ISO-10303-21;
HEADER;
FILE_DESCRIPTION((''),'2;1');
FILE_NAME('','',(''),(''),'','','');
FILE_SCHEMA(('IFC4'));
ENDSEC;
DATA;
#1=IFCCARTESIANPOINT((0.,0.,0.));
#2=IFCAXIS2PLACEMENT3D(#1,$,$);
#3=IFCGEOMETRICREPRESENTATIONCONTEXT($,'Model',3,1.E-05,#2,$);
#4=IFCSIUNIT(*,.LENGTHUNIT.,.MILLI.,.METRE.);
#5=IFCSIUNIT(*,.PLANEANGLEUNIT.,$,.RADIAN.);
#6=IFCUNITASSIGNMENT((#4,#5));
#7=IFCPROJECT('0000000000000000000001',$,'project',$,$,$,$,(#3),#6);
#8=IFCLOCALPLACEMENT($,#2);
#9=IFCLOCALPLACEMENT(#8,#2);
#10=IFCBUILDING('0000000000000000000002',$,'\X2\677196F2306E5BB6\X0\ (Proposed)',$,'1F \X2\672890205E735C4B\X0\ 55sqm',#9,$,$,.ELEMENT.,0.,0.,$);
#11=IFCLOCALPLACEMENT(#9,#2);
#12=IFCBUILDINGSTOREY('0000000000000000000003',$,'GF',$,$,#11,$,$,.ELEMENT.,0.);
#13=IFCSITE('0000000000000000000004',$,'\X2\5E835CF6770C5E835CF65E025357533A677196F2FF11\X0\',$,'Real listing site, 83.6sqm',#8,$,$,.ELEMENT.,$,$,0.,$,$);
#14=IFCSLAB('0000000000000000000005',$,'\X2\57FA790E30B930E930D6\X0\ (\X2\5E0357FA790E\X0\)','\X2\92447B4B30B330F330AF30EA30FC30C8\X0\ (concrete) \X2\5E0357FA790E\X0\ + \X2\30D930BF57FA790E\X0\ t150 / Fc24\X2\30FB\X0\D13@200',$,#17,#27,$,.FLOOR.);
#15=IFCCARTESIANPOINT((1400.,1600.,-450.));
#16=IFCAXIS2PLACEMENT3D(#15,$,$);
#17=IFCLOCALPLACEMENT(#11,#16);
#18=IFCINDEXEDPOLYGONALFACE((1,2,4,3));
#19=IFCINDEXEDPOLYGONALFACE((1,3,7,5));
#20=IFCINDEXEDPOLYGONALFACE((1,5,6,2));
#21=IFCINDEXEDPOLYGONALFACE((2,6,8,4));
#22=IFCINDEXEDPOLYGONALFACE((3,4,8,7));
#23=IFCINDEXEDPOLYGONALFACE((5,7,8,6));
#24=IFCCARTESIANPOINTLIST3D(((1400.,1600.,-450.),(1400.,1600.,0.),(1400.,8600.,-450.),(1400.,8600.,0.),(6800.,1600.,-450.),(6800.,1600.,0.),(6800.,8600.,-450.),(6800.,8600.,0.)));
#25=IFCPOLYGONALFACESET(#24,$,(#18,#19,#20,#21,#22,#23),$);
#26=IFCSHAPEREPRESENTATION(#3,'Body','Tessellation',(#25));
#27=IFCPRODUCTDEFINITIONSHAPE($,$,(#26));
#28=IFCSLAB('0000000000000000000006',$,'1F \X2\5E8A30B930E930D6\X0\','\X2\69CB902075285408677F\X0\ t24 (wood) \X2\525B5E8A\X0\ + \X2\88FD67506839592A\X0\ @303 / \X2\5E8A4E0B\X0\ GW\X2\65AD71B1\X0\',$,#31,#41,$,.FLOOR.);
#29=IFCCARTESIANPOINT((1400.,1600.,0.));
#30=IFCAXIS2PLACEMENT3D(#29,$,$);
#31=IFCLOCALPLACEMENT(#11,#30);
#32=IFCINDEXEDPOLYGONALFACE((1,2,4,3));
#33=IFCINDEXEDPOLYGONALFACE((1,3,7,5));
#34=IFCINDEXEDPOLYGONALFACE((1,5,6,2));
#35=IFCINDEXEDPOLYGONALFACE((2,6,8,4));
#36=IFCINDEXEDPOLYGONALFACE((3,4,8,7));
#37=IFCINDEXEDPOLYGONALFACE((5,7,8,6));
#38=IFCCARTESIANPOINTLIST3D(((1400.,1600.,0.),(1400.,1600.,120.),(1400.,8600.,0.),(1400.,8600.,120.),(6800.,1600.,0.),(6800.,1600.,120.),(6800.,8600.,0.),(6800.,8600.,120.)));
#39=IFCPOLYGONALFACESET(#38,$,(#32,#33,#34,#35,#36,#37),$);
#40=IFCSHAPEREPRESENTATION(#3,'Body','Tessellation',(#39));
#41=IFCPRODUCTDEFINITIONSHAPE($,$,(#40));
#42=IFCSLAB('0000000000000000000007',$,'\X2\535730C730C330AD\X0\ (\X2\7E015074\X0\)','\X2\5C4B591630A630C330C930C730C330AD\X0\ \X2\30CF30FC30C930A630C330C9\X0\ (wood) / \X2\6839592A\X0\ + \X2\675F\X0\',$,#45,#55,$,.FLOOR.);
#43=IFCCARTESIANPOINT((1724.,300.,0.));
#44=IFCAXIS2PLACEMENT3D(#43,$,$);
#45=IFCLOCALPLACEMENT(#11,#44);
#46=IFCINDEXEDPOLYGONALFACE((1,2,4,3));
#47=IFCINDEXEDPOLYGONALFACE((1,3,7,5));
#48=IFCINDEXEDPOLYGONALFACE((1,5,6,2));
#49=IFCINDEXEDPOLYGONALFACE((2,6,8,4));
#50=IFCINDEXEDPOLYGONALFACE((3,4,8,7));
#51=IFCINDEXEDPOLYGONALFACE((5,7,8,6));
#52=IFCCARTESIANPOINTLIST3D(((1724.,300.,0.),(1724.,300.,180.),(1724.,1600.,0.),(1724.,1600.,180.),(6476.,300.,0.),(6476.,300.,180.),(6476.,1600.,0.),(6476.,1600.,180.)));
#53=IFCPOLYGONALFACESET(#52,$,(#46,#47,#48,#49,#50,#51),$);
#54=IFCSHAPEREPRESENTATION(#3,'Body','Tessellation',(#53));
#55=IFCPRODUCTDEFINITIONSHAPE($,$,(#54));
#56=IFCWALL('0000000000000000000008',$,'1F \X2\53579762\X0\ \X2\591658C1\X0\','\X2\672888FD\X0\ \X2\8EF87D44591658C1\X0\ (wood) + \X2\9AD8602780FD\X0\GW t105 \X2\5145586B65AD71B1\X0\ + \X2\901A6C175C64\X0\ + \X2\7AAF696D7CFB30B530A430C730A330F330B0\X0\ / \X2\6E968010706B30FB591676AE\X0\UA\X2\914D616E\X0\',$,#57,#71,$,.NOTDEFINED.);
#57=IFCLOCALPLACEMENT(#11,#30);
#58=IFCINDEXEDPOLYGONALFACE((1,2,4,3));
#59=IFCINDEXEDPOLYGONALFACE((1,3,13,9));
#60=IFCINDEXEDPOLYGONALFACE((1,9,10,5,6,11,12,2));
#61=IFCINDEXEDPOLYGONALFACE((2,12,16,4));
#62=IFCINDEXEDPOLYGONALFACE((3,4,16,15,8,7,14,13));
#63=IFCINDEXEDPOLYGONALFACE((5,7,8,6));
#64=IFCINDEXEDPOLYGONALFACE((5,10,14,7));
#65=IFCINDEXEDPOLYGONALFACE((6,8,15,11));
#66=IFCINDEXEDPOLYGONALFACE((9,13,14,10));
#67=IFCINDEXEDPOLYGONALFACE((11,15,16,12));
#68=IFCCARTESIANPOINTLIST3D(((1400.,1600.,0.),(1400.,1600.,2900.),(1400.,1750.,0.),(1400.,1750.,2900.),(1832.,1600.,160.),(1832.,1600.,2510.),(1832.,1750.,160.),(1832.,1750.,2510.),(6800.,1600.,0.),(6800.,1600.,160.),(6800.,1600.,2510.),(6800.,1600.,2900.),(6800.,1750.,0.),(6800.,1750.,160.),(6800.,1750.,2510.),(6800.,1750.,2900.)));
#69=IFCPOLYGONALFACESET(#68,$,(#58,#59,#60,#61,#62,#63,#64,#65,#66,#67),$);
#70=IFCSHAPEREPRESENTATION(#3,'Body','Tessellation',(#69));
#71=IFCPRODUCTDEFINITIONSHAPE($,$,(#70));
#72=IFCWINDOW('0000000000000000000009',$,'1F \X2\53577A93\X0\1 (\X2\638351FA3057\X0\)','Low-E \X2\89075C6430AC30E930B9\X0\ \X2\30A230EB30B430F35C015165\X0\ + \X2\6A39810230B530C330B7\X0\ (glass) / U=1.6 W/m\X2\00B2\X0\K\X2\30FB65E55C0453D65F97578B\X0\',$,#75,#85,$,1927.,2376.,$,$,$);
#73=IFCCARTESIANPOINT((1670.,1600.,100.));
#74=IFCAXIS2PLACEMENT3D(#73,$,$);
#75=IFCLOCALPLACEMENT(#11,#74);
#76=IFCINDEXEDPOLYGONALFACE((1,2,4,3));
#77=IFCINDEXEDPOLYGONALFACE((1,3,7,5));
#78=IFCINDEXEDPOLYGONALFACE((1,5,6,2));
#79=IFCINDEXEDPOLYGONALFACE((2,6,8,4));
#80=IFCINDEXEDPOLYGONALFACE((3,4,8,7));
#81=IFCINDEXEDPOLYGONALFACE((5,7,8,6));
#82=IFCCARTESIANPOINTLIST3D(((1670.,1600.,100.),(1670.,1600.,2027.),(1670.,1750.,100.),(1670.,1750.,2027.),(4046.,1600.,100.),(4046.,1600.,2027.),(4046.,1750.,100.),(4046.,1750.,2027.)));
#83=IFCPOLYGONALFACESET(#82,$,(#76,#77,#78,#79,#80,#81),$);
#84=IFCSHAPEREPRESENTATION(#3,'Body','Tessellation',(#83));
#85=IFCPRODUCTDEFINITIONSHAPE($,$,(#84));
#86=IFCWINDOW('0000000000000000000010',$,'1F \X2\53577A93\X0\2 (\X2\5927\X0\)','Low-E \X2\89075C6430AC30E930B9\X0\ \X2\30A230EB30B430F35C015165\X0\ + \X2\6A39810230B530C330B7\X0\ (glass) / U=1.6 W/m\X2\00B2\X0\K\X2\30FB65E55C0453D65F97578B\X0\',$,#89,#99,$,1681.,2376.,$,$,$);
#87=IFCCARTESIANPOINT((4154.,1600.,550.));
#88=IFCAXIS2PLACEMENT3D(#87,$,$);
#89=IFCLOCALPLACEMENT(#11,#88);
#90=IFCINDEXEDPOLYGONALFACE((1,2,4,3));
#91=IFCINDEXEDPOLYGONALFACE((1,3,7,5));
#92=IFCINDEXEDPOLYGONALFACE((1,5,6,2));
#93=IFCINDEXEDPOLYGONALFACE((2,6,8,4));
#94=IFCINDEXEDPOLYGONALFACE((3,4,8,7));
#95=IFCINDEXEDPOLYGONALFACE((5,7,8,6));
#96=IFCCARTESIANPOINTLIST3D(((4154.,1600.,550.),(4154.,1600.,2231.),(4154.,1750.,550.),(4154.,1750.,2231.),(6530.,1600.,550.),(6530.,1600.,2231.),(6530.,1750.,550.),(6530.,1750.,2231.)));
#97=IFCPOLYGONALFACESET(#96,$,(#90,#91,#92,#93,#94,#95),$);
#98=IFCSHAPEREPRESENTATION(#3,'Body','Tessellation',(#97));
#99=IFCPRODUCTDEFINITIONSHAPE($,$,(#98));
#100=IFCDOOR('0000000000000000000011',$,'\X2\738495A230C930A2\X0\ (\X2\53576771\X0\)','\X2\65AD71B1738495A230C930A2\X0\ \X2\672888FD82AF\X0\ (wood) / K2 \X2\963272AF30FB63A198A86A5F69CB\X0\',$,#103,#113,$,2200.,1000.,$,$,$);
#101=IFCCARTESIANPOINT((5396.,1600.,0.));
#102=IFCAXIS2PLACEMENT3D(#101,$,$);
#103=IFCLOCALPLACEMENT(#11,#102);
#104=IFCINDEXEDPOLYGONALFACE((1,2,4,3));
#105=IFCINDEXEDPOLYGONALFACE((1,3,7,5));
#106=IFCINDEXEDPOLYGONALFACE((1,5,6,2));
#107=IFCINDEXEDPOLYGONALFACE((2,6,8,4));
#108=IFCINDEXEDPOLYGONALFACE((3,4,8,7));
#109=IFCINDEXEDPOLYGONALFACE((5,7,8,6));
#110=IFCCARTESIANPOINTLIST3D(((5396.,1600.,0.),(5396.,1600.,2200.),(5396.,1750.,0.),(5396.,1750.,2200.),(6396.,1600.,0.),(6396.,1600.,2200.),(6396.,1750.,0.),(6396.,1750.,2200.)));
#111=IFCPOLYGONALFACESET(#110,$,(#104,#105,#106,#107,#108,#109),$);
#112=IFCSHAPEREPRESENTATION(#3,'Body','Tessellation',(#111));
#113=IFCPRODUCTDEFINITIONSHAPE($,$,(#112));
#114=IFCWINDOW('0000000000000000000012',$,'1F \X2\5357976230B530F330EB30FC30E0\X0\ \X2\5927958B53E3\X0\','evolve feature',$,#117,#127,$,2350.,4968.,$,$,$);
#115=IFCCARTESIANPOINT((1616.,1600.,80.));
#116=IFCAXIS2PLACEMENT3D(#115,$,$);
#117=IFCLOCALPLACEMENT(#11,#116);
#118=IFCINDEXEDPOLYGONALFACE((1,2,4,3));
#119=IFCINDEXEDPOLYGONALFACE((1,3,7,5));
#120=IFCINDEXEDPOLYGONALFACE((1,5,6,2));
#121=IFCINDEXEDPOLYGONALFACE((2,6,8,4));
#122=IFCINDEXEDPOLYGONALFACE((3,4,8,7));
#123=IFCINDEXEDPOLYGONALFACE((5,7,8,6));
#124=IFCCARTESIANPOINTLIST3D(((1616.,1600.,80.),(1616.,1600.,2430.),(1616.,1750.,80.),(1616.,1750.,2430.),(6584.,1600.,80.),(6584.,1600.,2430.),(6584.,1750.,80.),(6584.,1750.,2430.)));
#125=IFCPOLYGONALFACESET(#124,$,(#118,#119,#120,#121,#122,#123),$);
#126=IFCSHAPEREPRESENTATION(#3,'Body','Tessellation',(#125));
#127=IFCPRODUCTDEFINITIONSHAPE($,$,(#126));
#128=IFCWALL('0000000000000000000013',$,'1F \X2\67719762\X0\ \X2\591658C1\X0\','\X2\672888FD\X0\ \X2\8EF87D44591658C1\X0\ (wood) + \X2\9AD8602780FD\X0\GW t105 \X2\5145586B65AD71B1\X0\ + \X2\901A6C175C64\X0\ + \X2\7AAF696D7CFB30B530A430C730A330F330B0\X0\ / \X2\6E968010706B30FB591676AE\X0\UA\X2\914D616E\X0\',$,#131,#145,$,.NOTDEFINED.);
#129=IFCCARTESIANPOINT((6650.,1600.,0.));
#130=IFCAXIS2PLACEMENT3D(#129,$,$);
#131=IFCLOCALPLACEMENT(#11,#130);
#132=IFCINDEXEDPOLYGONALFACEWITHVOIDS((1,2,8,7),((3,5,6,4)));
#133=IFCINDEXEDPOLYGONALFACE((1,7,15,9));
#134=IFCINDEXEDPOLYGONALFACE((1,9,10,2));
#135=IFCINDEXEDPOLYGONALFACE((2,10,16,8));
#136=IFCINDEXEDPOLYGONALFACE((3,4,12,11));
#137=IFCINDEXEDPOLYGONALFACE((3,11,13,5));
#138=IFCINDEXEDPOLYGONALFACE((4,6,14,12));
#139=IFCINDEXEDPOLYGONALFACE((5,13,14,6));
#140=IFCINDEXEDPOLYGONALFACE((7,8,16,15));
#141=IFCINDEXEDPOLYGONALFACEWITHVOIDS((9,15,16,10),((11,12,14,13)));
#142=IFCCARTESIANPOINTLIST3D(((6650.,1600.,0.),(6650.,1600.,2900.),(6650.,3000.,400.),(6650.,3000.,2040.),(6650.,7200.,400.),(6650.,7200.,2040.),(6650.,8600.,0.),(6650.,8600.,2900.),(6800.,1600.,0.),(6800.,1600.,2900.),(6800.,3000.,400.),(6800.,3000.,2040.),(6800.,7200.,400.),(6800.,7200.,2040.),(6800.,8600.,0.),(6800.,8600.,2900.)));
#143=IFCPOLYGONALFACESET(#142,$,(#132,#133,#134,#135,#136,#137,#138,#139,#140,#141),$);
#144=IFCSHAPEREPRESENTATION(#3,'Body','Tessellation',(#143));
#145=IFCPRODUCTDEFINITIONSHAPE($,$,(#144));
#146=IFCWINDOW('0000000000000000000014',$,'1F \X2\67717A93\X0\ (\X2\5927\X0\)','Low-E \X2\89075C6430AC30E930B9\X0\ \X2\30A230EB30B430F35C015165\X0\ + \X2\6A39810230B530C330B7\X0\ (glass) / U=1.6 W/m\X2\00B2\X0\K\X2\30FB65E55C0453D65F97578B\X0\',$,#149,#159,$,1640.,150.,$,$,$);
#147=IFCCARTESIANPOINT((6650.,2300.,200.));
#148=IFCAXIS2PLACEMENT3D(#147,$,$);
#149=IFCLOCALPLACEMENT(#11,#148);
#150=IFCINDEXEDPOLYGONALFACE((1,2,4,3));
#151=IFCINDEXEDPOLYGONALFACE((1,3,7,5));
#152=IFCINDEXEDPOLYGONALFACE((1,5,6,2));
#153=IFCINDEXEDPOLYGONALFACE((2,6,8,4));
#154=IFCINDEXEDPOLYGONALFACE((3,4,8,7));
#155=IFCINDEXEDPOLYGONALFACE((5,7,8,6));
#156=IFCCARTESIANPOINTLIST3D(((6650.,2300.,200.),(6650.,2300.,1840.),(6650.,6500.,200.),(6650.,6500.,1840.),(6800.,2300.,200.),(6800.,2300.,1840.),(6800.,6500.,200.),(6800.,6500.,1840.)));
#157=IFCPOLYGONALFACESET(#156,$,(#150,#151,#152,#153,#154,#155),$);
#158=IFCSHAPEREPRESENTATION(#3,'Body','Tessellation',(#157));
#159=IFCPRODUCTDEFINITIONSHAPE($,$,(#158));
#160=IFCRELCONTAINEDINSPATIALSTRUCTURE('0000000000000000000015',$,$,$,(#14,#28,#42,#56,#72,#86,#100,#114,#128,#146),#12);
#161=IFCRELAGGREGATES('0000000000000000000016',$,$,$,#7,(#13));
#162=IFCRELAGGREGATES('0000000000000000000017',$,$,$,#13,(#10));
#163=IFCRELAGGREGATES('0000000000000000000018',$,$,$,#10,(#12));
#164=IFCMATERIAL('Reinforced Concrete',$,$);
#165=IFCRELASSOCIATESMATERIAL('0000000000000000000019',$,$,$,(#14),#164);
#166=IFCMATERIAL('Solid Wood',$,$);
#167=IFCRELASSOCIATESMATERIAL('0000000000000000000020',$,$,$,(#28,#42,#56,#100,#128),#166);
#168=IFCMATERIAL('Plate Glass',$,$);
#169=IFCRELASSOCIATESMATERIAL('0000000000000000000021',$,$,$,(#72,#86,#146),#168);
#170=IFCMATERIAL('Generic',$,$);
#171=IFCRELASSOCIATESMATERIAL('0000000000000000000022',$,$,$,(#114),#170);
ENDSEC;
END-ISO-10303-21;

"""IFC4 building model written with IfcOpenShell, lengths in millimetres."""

from ifc_helpers import new_model, si_unit, frame, frame_2d, origin, place, context, project, spatial, rectangle, extrude, material, element, fill, save


model = new_model("IFC4")

# Units and contexts
model_context = context("Model", 3, precision=1e-05, world=origin())
ifc_project = project(units=[si_unit("LENGTHUNIT", "METRE", prefix="MILLI"), si_unit("PLANEANGLEUNIT", "RADIAN")], contexts=[model_context])

# Site, building, storey
site_placement = place(None, origin())
site = spatial("IfcSite", under=ifc_project, at=site_placement, Name="広島県広島市南区東雲１", ObjectType="Real listing site, 83.6sqm", CompositionType="ELEMENT", RefElevation=0.0)
building_placement = place(site_placement, origin())
building = spatial("IfcBuilding", under=site, at=building_placement, Name="東雲の家 (Proposed)", ObjectType="1F 木造平屋 55sqm", CompositionType="ELEMENT", ElevationOfRefHeight=0.0, ElevationOfTerrain=0.0)
storey_placement = place(building_placement, origin())
storey = spatial("IfcBuildingStorey", under=building, at=storey_placement, Name="GF", CompositionType="ELEMENT", Elevation=0.0)

# Slabs
ifc_material_1 = material(Name="Reinforced Concrete")
slab_1_placement = place(storey_placement, frame((1400.0, 1600.0, -450.0)))
element("IfcSlab", 1, at=slab_1_placement, inside=storey, material=ifc_material_1, Name="基礎スラブ (布基礎)", Description="鉄筋コンクリート (concrete) 布基礎 + ベタ基礎 t150 / Fc24・D13@200", PredefinedType="FLOOR", context=model_context, shape_type="SweptSolid", body=[
    extrude(rectangle(XDim=5400.0, YDim=7000.0, at=frame_2d((2700.0, 3500.0))), frame((1400.0, 1600.0, -450.0)), (0.0, 0.0, 1.0), 450.0),
])
ifc_material_2 = material(Name="Solid Wood")
slab_2_placement = place(storey_placement, frame((1400.0, 1600.0, 0.0)))
element("IfcSlab", 2, at=slab_2_placement, inside=storey, material=ifc_material_2, Name="1F 床スラブ", Description="構造用合板 t24 (wood) 剛床 + 製材根太 @303 / 床下 GW断熱", PredefinedType="FLOOR", context=model_context, shape_type="SweptSolid", body=[
    extrude(rectangle(XDim=5400.0, YDim=7000.0, at=frame_2d((2700.0, 3500.0))), frame((1400.0, 1600.0, 0.0)), (0.0, 0.0, 1.0), 120.0),
])
slab_3_placement = place(storey_placement, frame((1724.0, 300.0, 0.0)))
element("IfcSlab", 3, at=slab_3_placement, inside=storey, material=ifc_material_2, Name="南デッキ (縁側)", Description="屋外ウッドデッキ ハードウッド (wood) / 根太 + 束", PredefinedType="FLOOR", context=model_context, shape_type="SweptSolid", body=[
    extrude(rectangle(XDim=4752.0, YDim=1300.0, at=frame_2d((2376.0, 650.0))), frame((1724.0, 300.0, 0.0)), (0.0, 0.0, 1.0), 180.0),
])
ifc_material_3 = material(Name="Generic")

# Wall, openings, windows, door
wall_1_placement = place(storey_placement, frame((1400.0, 1600.0, 0.0)))
wall_1 = element("IfcWall", 4, at=wall_1_placement, inside=storey, material=ifc_material_2, Name="1F 南面 外壁", Description="木製 軸組外壁 (wood) + 高性能GW t105 充填断熱 + 通気層 + 窯業系サイディング / 準耐火・外皮UA配慮", PredefinedType="NOTDEFINED", context=model_context, shape_type="SweptSolid", body=[
    extrude(rectangle(XDim=5400.0, YDim=150.0, at=frame_2d((2700.0, 75.0))), frame((1400.0, 1600.0, 0.0)), (0.0, 0.0, 1.0), 2900.0),
])
opening_1_placement = place(storey_placement, frame((1670.0, 1600.0, 100.0)))
opening_1 = element("IfcOpeningElement", 5, at=opening_1_placement, cuts=wall_1, PredefinedType="NOTDEFINED", context=model_context, shape_type="SweptSolid", body=[
    extrude(rectangle(XDim=2376.0, YDim=150.0, at=frame_2d((1188.0, 75.0))), frame((1670.0, 1600.0, 100.0)), (0.0, 0.0, 1.0), 1927.0),
])
opening_2_placement = place(storey_placement, frame((4154.0, 1600.0, 550.0)))
opening_2 = element("IfcOpeningElement", 6, at=opening_2_placement, cuts=wall_1, PredefinedType="NOTDEFINED", context=model_context, shape_type="SweptSolid", body=[
    extrude(rectangle(XDim=2376.0, YDim=150.0, at=frame_2d((1188.0, 75.0))), frame((4154.0, 1600.0, 550.0)), (0.0, 0.0, 1.0), 1681.0),
])
opening_3_placement = place(storey_placement, frame((5396.0, 1600.0, 0.0)))
opening_3 = element("IfcOpeningElement", 7, at=opening_3_placement, cuts=wall_1, PredefinedType="NOTDEFINED", context=model_context, shape_type="SweptSolid", body=[
    extrude(rectangle(XDim=1000.0, YDim=150.0, at=frame_2d((500.0, 75.0))), frame((5396.0, 1600.0, 0.0)), (0.0, 0.0, 1.0), 2200.0),
])
opening_4_placement = place(storey_placement, frame((1616.0, 1600.0, 80.0)))
opening_4 = element("IfcOpeningElement", 8, at=opening_4_placement, cuts=wall_1, PredefinedType="NOTDEFINED", context=model_context, shape_type="SweptSolid", body=[
    extrude(rectangle(XDim=4968.0, YDim=150.0, at=frame_2d((2484.0, 75.0))), frame((1616.0, 1600.0, 80.0)), (0.0, 0.0, 1.0), 2350.0),
])
ifc_material_4 = material(Name="Plate Glass")
window_1_placement = place(storey_placement, frame((1670.0, 1600.0, 100.0)))
window_1 = element("IfcWindow", 9, at=window_1_placement, inside=storey, material=ifc_material_4, Name="1F 南窓1 (掃出し)", Description="Low-E 複層ガラス アルゴン封入 + 樹脂サッシ (glass) / U=1.6 W/m²K・日射取得型", OverallHeight=1927.0, OverallWidth=2376.0, context=model_context, shape_type="SweptSolid", body=[
    extrude(rectangle(XDim=2376.0, YDim=150.0, at=frame_2d((1188.0, 75.0))), frame((1670.0, 1600.0, 100.0)), (0.0, 0.0, 1.0), 1927.0),
])
fill(opening_1, window_1)
window_2_placement = place(storey_placement, frame((4154.0, 1600.0, 550.0)))
window_2 = element("IfcWindow", 10, at=window_2_placement, inside=storey, material=ifc_material_4, Name="1F 南窓2 (大)", Description="Low-E 複層ガラス アルゴン封入 + 樹脂サッシ (glass) / U=1.6 W/m²K・日射取得型", OverallHeight=1681.0, OverallWidth=2376.0, context=model_context, shape_type="SweptSolid", body=[
    extrude(rectangle(XDim=2376.0, YDim=150.0, at=frame_2d((1188.0, 75.0))), frame((4154.0, 1600.0, 550.0)), (0.0, 0.0, 1.0), 1681.0),
])
fill(opening_2, window_2)
door_placement = place(storey_placement, frame((5396.0, 1600.0, 0.0)))
door = element("IfcDoor", 11, at=door_placement, inside=storey, material=ifc_material_2, Name="玄関ドア (南東)", Description="断熱玄関ドア 木製芯 (wood) / K2 防犯・採風機構", OverallHeight=2200.0, OverallWidth=1000.0, context=model_context, shape_type="SweptSolid", body=[
    extrude(rectangle(XDim=1000.0, YDim=150.0, at=frame_2d((500.0, 75.0))), frame((5396.0, 1600.0, 0.0)), (0.0, 0.0, 1.0), 2200.0),
])
fill(opening_3, door)
window_3_placement = place(storey_placement, frame((1616.0, 1600.0, 80.0)))
window_3 = element("IfcWindow", 12, at=window_3_placement, inside=storey, material=ifc_material_3, Name="1F 南面サンルーム 大開口", Description="evolve feature", OverallHeight=2350.0, OverallWidth=4968.0, context=model_context, shape_type="SweptSolid", body=[
    extrude(rectangle(XDim=4968.0, YDim=150.0, at=frame_2d((2484.0, 75.0))), frame((1616.0, 1600.0, 80.0)), (0.0, 0.0, 1.0), 2350.0),
])
fill(opening_4, window_3)

# Wall, opening, window
wall_2_placement = place(storey_placement, frame((6650.0, 1600.0, 0.0)))
wall_2 = element("IfcWall", 13, at=wall_2_placement, inside=storey, material=ifc_material_2, Name="1F 東面 外壁", Description="木製 軸組外壁 (wood) + 高性能GW t105 充填断熱 + 通気層 + 窯業系サイディング / 準耐火・外皮UA配慮", PredefinedType="NOTDEFINED", context=model_context, shape_type="SweptSolid", body=[
    extrude(rectangle(XDim=150.0, YDim=7000.0, at=frame_2d((75.0, 3500.0))), frame((6650.0, 1600.0, 0.0)), (0.0, 0.0, 1.0), 2900.0),
])
opening_5_placement = place(storey_placement, frame((6650.0, 2300.0, 200.0)))
opening_5 = element("IfcOpeningElement", 14, at=opening_5_placement, cuts=wall_2, PredefinedType="NOTDEFINED", context=model_context, shape_type="SweptSolid", body=[
    extrude(rectangle(XDim=150.0, YDim=4200.0, at=frame_2d((75.0, 2100.0))), frame((6650.0, 2300.0, 200.0)), (0.0, 0.0, 1.0), 1640.0),
])
window_4_placement = place(storey_placement, frame((6650.0, 2300.0, 200.0)))
window_4 = element("IfcWindow", 15, at=window_4_placement, inside=storey, material=ifc_material_4, Name="1F 東窓 (大)", Description="Low-E 複層ガラス アルゴン封入 + 樹脂サッシ (glass) / U=1.6 W/m²K・日射取得型", OverallHeight=1640.0, OverallWidth=150.0, context=model_context, shape_type="SweptSolid", body=[
    extrude(rectangle(XDim=150.0, YDim=4200.0, at=frame_2d((75.0, 2100.0))), frame((6650.0, 2300.0, 200.0)), (0.0, 0.0, 1.0), 1640.0),
])
fill(opening_5, window_4)

save(model, "model.ifc")
